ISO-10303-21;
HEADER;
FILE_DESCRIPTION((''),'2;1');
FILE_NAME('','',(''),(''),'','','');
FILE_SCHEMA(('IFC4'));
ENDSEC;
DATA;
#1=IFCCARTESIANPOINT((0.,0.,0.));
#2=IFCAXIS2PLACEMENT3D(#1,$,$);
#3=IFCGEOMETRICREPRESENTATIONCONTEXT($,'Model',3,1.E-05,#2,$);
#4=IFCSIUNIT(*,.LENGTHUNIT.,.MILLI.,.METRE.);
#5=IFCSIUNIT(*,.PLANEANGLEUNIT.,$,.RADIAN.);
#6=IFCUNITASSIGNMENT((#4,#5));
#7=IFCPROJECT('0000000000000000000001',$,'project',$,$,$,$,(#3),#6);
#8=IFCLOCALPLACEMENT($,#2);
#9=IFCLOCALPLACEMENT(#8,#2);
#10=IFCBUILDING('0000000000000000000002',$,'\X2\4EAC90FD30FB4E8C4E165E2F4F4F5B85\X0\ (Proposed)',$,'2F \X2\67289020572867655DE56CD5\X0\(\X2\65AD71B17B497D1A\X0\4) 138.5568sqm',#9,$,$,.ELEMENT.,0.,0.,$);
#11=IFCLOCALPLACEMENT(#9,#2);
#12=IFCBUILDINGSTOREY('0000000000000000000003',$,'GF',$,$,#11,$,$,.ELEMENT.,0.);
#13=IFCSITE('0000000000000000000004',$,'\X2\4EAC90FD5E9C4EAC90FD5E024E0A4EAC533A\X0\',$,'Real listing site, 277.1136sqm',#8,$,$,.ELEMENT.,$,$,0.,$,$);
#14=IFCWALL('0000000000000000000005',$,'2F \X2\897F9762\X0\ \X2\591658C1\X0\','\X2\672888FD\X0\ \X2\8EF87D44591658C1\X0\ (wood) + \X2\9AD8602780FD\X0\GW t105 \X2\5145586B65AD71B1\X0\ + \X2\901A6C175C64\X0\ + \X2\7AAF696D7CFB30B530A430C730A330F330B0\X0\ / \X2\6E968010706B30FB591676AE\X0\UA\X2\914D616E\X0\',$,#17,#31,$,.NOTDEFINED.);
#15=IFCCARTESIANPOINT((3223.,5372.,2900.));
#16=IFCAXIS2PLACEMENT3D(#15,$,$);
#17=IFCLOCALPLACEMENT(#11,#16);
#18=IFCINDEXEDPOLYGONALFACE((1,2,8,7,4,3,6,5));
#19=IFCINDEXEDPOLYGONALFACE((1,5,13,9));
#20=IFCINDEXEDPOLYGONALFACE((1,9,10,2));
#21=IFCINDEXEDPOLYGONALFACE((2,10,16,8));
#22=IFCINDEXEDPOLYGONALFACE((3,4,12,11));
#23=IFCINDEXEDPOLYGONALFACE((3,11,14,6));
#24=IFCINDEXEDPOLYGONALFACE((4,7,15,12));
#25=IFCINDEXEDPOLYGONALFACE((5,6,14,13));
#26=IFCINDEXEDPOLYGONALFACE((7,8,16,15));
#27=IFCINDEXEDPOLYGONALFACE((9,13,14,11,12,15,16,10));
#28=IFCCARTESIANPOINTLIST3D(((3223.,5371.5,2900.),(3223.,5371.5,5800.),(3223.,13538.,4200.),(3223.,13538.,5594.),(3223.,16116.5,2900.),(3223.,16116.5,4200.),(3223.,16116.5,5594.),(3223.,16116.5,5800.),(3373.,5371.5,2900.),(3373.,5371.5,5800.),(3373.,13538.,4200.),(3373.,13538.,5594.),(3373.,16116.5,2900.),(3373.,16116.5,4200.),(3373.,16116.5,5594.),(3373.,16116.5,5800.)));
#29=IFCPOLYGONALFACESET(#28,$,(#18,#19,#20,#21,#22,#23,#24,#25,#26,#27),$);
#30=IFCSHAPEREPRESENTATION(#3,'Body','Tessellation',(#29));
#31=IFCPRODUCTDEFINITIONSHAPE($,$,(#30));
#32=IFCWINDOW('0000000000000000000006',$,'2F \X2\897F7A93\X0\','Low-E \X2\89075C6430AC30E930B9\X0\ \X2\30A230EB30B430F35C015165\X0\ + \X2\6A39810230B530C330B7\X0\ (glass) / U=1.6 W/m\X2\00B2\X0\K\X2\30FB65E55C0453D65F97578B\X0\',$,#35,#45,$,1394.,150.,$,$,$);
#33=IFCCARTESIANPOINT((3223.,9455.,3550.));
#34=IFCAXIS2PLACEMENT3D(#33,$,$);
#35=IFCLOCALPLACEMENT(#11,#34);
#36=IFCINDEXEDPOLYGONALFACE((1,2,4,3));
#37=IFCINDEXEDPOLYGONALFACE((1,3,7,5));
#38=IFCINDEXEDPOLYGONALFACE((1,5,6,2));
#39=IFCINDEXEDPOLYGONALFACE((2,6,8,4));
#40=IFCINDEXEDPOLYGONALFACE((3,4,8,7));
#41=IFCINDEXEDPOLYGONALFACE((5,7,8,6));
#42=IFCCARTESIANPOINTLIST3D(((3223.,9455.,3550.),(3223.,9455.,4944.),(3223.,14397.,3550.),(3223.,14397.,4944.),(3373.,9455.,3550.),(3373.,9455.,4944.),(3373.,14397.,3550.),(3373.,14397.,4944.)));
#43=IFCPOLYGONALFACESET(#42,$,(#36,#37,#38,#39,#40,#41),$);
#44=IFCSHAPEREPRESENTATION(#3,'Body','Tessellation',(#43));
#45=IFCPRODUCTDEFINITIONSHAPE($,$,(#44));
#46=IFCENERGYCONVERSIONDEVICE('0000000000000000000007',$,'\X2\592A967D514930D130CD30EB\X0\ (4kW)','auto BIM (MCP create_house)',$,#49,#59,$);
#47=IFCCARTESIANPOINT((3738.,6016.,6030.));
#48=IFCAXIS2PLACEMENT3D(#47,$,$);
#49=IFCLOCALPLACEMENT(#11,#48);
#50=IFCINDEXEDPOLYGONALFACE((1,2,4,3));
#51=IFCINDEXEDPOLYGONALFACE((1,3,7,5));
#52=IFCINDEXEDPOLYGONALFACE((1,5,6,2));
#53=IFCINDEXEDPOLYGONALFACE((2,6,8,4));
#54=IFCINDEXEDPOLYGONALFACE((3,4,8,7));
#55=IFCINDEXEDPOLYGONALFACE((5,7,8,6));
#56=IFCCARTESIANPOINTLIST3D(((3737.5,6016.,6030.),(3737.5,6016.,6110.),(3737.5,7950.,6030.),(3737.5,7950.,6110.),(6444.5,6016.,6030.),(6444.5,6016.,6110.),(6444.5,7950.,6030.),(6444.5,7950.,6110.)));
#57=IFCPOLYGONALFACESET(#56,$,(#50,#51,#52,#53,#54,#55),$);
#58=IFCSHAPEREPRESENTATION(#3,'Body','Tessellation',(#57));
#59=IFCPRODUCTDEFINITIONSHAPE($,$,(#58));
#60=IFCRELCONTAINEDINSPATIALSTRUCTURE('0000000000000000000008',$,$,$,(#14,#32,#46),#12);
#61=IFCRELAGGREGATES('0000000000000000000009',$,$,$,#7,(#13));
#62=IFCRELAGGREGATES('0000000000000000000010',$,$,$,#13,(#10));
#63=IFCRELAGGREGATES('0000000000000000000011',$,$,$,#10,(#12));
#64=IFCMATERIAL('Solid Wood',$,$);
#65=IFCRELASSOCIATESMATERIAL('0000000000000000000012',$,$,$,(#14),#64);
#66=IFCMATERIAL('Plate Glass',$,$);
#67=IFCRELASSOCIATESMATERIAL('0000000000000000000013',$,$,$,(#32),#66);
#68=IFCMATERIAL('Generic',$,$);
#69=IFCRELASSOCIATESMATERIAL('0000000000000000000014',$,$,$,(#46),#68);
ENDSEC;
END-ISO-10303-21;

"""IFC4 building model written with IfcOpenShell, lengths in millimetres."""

from ifc_helpers import new_model, si_unit, frame, frame_2d, origin, place, context, project, spatial, rectangle, extrude, material, element, fill, save


model = new_model("IFC4")

# Units and contexts
model_context = context("Model", 3, precision=1e-05, world=origin())
ifc_project = project(units=[si_unit("LENGTHUNIT", "METRE", prefix="MILLI"), si_unit("PLANEANGLEUNIT", "RADIAN")], contexts=[model_context])

# Site, building, storey
site_placement = place(None, origin())
site = spatial("IfcSite", under=ifc_project, at=site_placement, Name="京都府京都市上京区", ObjectType="Real listing site, 277.1136sqm", CompositionType="ELEMENT", RefElevation=0.0)
building_placement = place(site_placement, origin())
building = spatial("IfcBuilding", under=site, at=building_placement, Name="京都・二世帯住宅 (Proposed)", ObjectType="2F 木造在来工法(断熱等級4) 138.5568sqm", CompositionType="ELEMENT", ElevationOfRefHeight=0.0, ElevationOfTerrain=0.0)
storey_placement = place(building_placement, origin())
storey = spatial("IfcBuildingStorey", under=building, at=storey_placement, Name="GF", CompositionType="ELEMENT", Elevation=0.0)

# Shared definitions
ifc_material_1 = material(Name="Solid Wood")

# Shared definitions
ifc_material_2 = material(Name="Plate Glass")

# Wall, opening, window
wall_1_placement = place(storey_placement, frame((3223.0, 5372.0, 2900.0)))
wall_1 = element("IfcWall", 1, at=wall_1_placement, inside=storey, material=ifc_material_1, Name="2F 西面 外壁", Description="木製 軸組外壁 (wood) + 高性能GW t105 充填断熱 + 通気層 + 窯業系サイディング / 準耐火・外皮UA配慮", PredefinedType="NOTDEFINED", context=model_context, shape_type="SweptSolid", body=[
    extrude(rectangle(XDim=150.0, YDim=10745.0, at=frame_2d((75.0, 5372.0))), frame((3223.0, 5372.0, 2900.0)), (0.0, 0.0, 1.0), 2900.0),
])
opening_1_placement = place(storey_placement, frame((3223.0, 9455.0, 3550.0)))
opening_1 = element("IfcOpeningElement", 2, at=opening_1_placement, cuts=wall_1, PredefinedType="NOTDEFINED", context=model_context, shape_type="SweptSolid", body=[
    extrude(rectangle(XDim=150.0, YDim=4942.0, at=frame_2d((75.0, 2471.0))), frame((3223.0, 9455.0, 3550.0)), (0.0, 0.0, 1.0), 1394.0),
])
window_1_placement = place(storey_placement, frame((3223.0, 9455.0, 3550.0)))
window_1 = element("IfcWindow", 3, at=window_1_placement, inside=storey, material=ifc_material_2, Name="2F 西窓", Description="Low-E 複層ガラス アルゴン封入 + 樹脂サッシ (glass) / U=1.6 W/m²K・日射取得型", OverallHeight=1394.0, OverallWidth=150.0, context=model_context, shape_type="SweptSolid", body=[
    extrude(rectangle(XDim=150.0, YDim=4942.0, at=frame_2d((75.0, 2471.0))), frame((3223.0, 9455.0, 3550.0)), (0.0, 0.0, 1.0), 1394.0),
])
fill(opening_1, window_1)

# Shared definitions
ifc_material_3 = material(Name="Generic")

# Energy conversion device
energy_conversion_device_placement = place(storey_placement, frame((3738.0, 6016.0, 6030.0)))
element("IfcEnergyConversionDevice", 4, at=energy_conversion_device_placement, inside=storey, material=ifc_material_3, Name="太陽光パネル (4kW)", Description="auto BIM (MCP create_house)", context=model_context, shape_type="SweptSolid", body=[
    extrude(rectangle(XDim=2707.0, YDim=1934.0, at=frame_2d((1353.0, 967.0))), frame((3738.0, 6016.0, 6030.0)), (0.0, 0.0, 1.0), 80.0),
])

save(model, "model.ifc")
